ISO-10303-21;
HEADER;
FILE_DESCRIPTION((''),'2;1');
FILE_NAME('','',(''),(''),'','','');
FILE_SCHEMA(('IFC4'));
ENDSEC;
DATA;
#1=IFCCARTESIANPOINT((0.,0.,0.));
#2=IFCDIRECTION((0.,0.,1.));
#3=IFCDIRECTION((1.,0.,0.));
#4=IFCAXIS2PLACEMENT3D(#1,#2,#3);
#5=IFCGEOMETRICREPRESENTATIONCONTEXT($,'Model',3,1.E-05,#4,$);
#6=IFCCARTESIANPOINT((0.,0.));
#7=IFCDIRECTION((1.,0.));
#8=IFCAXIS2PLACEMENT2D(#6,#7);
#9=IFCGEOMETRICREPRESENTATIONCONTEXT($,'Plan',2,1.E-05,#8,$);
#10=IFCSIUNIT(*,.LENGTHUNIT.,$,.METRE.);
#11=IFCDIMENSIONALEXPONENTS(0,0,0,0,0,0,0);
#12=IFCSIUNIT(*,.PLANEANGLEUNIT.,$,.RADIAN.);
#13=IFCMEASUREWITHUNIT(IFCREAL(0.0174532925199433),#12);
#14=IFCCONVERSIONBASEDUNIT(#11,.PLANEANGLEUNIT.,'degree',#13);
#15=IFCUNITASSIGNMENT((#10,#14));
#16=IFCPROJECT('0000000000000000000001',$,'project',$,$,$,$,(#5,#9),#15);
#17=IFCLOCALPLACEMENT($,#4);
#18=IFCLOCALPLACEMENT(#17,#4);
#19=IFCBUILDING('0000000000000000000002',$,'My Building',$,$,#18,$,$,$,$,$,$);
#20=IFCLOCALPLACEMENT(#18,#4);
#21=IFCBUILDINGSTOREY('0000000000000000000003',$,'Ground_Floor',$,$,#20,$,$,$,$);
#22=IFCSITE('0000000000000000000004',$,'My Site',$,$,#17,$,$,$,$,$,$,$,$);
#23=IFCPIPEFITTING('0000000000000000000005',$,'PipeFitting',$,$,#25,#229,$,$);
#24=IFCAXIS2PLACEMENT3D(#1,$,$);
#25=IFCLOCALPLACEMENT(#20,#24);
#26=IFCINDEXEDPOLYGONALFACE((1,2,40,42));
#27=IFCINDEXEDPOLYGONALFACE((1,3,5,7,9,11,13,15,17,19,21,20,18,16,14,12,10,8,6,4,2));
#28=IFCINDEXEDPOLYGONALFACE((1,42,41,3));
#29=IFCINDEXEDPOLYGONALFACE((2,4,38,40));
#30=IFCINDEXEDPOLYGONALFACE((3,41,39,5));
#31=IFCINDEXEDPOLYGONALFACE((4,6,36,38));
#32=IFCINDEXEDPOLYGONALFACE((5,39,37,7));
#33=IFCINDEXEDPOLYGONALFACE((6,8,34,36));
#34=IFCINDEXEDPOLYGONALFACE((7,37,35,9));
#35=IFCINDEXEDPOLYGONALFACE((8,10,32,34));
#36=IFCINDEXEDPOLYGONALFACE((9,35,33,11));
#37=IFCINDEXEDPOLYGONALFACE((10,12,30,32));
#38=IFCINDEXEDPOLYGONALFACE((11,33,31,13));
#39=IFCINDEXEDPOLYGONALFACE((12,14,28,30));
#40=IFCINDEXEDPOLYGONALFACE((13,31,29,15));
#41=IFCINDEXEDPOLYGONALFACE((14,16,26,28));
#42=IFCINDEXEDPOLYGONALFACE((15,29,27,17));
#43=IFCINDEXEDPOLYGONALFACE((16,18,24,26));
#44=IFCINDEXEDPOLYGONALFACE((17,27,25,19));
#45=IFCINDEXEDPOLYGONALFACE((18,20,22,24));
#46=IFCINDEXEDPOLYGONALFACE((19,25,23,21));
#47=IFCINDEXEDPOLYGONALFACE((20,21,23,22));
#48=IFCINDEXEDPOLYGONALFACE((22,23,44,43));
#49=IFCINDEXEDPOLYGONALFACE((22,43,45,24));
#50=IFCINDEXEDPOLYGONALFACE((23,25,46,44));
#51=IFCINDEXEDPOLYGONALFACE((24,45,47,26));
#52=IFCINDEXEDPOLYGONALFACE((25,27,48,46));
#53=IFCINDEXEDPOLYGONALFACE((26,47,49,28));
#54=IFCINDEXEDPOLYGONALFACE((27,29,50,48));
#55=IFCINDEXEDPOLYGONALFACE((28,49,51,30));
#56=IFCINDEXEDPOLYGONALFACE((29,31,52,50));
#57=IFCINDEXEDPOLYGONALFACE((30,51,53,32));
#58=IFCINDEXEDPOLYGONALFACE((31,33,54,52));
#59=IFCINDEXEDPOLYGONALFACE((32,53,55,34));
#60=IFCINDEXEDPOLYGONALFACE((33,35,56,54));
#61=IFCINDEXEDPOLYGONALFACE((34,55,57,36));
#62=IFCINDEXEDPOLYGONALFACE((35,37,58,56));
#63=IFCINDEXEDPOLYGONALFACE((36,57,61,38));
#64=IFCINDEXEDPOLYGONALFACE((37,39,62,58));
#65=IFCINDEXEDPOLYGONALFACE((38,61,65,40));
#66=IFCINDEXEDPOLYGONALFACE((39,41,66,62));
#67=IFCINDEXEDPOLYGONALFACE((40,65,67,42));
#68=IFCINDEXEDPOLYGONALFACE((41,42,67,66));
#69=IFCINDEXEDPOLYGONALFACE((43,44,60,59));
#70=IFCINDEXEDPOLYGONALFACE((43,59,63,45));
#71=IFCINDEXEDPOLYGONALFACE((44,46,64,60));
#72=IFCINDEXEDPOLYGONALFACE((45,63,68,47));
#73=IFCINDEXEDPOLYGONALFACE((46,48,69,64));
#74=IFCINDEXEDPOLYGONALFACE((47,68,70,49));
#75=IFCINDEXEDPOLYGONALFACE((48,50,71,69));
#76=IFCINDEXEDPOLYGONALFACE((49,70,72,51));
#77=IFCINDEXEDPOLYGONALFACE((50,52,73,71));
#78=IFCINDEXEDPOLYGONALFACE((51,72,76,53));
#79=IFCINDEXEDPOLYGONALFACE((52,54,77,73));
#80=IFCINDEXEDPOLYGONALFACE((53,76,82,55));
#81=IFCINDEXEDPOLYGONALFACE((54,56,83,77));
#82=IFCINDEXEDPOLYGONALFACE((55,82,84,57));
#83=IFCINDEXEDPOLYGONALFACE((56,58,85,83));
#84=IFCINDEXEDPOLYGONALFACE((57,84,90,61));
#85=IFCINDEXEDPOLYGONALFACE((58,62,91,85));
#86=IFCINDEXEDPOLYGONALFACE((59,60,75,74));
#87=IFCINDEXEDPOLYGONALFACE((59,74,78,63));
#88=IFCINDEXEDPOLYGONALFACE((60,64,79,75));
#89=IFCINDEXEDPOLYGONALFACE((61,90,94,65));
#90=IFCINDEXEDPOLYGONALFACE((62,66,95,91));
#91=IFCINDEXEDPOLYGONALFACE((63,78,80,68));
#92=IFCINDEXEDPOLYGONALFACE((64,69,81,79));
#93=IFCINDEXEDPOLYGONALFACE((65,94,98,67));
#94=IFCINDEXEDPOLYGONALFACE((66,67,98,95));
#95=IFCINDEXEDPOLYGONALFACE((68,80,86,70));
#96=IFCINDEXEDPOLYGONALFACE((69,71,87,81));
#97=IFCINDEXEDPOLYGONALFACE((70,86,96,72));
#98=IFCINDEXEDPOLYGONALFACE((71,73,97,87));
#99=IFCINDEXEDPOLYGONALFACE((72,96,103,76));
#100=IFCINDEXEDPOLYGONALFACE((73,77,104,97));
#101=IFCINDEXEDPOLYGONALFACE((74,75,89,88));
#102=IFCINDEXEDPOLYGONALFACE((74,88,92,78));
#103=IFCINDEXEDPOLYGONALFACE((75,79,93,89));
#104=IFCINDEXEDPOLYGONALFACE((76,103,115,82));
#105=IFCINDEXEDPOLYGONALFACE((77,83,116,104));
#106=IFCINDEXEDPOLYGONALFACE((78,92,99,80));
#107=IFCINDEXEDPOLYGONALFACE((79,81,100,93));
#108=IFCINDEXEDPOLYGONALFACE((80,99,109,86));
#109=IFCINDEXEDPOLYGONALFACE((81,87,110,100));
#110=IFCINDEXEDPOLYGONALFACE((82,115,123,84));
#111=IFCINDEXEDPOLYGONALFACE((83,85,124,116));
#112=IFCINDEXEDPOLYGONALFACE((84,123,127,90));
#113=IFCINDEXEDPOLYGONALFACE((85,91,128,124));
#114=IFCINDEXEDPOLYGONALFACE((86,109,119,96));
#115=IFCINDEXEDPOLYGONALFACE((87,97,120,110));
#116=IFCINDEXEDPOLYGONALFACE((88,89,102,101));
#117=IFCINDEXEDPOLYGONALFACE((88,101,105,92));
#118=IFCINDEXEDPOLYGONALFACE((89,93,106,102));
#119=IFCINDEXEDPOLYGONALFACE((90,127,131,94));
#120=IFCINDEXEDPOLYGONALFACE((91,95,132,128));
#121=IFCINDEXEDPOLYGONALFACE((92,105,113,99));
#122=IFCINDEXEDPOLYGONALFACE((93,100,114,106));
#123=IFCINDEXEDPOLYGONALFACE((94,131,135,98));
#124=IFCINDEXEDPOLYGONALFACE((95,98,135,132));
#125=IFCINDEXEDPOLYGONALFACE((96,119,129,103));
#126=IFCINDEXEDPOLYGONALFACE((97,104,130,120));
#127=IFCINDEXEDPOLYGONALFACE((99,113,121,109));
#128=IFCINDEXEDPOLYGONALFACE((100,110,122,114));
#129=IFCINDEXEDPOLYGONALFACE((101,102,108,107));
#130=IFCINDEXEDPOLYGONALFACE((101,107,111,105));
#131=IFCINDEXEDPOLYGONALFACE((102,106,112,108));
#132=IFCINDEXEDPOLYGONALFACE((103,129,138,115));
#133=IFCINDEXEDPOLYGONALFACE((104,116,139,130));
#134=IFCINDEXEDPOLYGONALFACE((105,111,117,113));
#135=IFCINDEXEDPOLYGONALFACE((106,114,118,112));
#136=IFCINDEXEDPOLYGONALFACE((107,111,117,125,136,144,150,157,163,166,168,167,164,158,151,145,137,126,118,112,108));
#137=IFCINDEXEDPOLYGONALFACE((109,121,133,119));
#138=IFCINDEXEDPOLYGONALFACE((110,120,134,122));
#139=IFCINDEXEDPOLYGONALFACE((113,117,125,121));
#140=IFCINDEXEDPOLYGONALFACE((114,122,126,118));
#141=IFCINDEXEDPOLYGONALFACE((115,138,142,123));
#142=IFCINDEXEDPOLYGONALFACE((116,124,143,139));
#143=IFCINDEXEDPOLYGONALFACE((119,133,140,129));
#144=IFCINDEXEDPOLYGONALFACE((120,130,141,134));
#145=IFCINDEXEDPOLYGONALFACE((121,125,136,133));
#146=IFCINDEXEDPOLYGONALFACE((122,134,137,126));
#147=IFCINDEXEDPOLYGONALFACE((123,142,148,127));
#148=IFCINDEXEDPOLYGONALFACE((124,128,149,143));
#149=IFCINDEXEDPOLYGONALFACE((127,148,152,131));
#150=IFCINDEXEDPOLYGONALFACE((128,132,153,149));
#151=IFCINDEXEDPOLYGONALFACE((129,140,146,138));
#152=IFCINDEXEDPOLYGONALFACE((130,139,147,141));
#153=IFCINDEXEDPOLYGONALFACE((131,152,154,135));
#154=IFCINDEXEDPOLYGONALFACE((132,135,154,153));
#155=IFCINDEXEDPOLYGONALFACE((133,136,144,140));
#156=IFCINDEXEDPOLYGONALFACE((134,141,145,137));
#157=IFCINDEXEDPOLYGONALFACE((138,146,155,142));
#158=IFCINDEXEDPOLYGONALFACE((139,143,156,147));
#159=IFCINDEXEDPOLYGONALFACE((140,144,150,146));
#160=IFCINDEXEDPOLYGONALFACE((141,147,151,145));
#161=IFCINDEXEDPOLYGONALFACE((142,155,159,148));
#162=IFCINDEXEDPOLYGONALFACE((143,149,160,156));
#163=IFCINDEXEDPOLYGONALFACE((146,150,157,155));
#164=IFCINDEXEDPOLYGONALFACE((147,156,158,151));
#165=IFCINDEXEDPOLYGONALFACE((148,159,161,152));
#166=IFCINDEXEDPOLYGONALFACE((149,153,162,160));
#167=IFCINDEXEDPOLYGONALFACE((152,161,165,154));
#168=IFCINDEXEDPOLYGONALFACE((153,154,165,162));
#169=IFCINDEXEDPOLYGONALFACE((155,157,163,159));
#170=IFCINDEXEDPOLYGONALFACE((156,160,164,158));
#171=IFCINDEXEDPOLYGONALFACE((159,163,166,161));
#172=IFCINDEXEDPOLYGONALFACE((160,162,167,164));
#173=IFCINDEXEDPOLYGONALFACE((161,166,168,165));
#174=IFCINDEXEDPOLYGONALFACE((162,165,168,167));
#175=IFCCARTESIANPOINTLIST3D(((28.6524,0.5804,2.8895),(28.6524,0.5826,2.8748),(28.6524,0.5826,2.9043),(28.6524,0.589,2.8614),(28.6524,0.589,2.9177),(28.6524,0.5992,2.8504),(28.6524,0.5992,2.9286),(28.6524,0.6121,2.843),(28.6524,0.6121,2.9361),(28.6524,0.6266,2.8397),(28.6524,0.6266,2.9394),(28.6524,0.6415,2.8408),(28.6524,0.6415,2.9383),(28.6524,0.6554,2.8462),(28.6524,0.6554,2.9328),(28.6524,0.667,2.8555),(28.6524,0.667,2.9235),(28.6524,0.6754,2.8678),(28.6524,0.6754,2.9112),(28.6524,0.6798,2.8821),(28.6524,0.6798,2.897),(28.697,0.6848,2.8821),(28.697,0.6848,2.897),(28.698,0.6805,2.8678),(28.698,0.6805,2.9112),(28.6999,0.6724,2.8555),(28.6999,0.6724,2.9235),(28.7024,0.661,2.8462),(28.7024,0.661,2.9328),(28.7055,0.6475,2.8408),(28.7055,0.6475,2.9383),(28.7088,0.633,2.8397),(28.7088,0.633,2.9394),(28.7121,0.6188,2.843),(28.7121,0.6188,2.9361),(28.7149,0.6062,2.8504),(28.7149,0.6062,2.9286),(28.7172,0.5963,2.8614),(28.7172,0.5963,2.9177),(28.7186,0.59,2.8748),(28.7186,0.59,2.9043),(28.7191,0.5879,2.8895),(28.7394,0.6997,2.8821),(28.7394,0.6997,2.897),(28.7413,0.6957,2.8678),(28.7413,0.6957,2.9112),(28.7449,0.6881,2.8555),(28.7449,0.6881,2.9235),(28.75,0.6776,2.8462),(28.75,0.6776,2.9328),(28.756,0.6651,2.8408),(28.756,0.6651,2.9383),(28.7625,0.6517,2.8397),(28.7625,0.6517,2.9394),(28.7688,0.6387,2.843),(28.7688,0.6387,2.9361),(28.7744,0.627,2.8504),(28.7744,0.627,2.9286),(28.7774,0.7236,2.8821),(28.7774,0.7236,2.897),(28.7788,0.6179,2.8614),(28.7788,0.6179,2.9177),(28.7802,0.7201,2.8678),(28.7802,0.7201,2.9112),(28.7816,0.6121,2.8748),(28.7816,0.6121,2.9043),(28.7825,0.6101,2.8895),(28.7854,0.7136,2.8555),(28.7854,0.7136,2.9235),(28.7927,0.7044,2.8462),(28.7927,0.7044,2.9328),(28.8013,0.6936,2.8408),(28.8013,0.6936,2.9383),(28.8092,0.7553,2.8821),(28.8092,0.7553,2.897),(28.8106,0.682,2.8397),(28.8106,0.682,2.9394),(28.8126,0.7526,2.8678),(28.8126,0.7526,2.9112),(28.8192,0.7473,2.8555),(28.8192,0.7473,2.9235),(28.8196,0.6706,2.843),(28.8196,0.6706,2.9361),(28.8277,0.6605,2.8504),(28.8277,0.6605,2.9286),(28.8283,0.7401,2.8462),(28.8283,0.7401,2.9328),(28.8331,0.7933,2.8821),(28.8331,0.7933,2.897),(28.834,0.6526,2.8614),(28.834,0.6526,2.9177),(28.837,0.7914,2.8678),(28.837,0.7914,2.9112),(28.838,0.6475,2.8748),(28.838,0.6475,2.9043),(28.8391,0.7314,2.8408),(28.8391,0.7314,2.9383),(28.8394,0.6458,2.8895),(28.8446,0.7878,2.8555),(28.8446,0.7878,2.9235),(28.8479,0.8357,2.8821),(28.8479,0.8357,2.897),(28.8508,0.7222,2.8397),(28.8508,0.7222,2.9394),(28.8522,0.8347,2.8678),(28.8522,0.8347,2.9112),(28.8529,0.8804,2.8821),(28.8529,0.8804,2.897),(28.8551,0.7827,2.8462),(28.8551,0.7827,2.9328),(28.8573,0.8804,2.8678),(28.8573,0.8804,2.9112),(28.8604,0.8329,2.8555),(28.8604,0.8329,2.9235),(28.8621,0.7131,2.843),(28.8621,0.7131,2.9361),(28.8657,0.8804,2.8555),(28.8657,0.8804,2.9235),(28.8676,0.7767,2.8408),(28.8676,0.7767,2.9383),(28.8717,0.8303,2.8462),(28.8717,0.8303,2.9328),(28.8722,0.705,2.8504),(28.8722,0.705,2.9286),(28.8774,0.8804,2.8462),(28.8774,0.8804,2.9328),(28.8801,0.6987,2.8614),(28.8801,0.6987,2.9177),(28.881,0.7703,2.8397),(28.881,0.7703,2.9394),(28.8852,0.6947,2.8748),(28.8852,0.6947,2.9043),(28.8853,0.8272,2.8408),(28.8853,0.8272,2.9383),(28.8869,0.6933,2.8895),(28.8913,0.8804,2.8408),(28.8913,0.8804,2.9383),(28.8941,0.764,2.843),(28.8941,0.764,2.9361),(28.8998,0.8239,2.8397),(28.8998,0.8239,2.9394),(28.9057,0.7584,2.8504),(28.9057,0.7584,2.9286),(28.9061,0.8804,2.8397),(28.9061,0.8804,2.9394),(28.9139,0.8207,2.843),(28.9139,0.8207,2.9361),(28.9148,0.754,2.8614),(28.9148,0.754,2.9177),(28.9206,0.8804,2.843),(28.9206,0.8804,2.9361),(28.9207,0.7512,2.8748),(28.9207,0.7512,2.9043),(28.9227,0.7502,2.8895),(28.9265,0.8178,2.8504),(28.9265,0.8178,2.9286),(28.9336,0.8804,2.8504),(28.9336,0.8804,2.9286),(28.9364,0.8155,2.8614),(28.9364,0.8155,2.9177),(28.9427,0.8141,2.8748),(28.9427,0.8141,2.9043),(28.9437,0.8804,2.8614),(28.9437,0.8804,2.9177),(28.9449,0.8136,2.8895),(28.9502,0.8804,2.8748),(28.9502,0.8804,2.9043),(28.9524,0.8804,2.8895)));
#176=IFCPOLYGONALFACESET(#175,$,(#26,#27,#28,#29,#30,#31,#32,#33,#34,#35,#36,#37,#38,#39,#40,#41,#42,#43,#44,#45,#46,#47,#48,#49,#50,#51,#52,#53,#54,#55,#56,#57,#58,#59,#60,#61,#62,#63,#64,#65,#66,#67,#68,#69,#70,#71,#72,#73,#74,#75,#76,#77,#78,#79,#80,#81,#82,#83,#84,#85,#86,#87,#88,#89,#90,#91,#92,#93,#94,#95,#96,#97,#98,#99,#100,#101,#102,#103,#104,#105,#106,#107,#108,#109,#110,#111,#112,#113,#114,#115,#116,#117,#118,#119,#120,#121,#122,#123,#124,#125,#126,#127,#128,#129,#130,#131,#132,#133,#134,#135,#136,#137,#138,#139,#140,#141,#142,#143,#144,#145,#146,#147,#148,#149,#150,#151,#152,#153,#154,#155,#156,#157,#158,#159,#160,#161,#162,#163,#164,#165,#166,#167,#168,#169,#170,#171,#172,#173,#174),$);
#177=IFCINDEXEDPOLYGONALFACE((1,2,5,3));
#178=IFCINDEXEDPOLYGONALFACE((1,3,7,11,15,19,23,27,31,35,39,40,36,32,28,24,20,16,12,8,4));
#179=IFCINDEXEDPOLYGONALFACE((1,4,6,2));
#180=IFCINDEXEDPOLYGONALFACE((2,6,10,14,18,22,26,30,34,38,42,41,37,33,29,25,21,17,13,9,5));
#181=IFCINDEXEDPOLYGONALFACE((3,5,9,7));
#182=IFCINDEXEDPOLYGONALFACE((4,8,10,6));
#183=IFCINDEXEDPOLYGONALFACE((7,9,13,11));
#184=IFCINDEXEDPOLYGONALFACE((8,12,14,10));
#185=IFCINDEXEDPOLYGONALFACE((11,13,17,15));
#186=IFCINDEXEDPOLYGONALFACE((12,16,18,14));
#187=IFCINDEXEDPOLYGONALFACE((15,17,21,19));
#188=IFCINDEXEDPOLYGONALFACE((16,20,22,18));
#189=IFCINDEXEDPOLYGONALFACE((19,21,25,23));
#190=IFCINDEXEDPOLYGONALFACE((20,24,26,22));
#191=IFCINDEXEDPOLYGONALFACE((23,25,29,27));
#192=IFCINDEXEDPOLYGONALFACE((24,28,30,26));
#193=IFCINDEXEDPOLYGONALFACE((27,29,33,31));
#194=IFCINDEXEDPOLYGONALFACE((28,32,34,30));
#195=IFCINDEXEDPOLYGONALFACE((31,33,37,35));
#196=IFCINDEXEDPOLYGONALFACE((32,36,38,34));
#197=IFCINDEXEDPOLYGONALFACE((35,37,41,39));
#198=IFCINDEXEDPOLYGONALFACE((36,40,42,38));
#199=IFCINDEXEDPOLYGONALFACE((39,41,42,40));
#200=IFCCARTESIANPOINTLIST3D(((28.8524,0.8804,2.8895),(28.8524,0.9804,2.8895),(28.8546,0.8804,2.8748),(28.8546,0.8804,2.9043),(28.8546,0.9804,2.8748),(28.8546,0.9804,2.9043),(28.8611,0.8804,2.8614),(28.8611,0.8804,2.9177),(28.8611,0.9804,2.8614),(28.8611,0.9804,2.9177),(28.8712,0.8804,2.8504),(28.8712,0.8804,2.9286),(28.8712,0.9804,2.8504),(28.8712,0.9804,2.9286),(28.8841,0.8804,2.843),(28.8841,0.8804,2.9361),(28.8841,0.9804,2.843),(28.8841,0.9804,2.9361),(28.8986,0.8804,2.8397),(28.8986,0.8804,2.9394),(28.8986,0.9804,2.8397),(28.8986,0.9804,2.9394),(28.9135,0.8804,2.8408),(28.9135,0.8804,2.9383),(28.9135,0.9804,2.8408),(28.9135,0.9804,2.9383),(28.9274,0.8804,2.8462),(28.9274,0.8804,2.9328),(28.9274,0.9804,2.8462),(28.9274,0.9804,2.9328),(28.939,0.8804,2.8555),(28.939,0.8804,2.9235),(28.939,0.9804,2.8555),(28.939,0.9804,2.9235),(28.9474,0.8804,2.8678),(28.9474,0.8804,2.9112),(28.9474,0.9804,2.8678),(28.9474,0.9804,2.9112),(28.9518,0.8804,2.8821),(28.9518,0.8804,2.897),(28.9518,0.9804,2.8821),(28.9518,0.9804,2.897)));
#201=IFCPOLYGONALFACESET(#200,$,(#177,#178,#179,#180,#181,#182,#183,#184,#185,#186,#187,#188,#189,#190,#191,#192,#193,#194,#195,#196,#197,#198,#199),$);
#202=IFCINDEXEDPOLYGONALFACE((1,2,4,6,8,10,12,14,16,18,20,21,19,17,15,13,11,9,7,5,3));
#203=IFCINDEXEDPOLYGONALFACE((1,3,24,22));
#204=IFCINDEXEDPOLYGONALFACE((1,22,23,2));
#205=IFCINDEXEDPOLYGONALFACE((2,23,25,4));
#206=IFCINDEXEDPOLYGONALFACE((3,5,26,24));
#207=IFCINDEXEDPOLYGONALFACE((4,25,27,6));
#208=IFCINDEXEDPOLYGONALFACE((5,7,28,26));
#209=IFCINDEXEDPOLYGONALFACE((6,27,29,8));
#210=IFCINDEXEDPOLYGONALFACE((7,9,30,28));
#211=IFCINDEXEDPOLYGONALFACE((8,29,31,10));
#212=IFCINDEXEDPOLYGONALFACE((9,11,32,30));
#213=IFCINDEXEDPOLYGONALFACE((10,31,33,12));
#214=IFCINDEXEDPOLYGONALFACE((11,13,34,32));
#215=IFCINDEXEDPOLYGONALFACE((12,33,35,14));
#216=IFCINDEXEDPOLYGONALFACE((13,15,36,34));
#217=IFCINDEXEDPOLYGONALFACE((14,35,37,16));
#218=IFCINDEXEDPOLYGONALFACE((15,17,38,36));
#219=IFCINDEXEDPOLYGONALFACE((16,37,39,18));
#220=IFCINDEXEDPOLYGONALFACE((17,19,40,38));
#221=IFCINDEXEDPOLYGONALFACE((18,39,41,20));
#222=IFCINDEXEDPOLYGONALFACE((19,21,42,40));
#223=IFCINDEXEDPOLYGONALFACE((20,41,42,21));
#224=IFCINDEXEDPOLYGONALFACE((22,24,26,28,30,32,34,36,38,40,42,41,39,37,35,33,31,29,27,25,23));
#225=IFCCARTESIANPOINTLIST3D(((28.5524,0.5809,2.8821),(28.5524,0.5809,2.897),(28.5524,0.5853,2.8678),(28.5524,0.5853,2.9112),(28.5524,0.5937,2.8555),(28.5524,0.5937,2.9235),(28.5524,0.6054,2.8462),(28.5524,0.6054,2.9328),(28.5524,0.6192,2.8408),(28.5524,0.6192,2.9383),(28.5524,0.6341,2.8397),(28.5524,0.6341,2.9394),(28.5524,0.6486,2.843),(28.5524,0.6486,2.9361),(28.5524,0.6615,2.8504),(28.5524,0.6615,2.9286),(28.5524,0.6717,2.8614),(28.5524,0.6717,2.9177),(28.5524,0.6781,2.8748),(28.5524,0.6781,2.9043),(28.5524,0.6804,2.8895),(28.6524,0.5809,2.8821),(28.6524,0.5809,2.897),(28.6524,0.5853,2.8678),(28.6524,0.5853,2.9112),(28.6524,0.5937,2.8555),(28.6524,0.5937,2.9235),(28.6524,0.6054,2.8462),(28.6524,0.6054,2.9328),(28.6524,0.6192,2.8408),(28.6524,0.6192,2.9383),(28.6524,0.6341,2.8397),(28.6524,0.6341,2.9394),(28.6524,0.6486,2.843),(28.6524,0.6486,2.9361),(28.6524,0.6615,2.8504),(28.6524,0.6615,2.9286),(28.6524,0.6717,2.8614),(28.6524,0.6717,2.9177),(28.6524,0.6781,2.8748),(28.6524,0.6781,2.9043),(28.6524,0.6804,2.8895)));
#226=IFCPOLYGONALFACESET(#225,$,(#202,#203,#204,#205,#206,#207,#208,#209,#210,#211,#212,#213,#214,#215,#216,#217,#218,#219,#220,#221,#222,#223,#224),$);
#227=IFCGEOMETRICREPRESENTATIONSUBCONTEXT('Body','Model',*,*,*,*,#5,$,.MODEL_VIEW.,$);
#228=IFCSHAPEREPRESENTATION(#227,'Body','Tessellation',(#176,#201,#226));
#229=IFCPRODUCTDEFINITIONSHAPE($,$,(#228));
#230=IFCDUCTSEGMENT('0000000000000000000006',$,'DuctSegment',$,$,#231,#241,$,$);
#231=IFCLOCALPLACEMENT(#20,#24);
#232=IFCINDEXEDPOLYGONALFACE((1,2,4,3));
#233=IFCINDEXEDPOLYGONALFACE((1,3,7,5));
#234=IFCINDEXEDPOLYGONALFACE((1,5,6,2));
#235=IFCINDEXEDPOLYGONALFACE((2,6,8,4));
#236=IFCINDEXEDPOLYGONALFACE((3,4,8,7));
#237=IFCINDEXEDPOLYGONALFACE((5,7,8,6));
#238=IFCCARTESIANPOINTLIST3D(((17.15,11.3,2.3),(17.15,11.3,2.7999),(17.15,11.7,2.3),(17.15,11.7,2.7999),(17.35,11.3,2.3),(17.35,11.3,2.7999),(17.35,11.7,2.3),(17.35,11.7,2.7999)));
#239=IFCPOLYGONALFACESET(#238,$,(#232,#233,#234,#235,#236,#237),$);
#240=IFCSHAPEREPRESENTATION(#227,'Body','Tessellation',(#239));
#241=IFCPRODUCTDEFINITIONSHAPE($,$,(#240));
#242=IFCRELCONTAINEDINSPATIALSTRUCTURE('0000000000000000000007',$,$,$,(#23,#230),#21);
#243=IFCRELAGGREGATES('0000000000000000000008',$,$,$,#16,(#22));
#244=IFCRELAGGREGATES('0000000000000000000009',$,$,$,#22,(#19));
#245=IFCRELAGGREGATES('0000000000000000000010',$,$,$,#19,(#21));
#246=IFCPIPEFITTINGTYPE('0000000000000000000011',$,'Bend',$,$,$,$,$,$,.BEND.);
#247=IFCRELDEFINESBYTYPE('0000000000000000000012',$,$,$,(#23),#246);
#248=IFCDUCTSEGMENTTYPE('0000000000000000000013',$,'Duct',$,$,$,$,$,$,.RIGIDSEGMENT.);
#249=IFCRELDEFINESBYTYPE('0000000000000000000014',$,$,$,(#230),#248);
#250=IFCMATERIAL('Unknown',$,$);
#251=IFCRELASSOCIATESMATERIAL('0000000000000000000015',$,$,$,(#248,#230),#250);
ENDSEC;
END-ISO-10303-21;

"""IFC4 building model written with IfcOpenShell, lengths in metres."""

from ifc_helpers import new_model, entity, si_unit, converted_unit, frame, origin_with_axes, origin_2d_with_axis, place, context, subcontext, project, spatial, rectangle, circle, extrude, source, transform, mapped, material, material_profile, profile_set, profile_usage, type_object, type_shapes, element, save


model = new_model("IFC4")

# Units and contexts
model_context = context("Model", 3, precision=1e-05, world=origin_with_axes())
plan_context = context("Plan", 2, precision=1e-05, world=origin_2d_with_axis())
body_context_1 = subcontext(model_context, "Body", "Model", "MODEL_VIEW")
ifc_project = project(units=[si_unit("LENGTHUNIT", "METRE"), converted_unit("PLANEANGLEUNIT", "degree", entity("IfcReal", 0.0174532925199433), si_unit("PLANEANGLEUNIT", "RADIAN"), dimensions=[0, 0, 0, 0, 0, 0, 0])], contexts=[model_context, plan_context])

# Site, building, storey
site_placement = place(None, origin_with_axes())
site = spatial("IfcSite", under=ifc_project, at=site_placement, Name="My Site")
building_placement = place(site_placement, origin_with_axes())
building = spatial("IfcBuilding", under=site, at=building_placement, Name="My Building")
storey_placement = place(building_placement, origin_with_axes())
storey = spatial("IfcBuildingStorey", under=building, at=storey_placement, Name="Ground_Floor")

# Shared definitions
ifc_material = material(Name="Unknown")

# Pipe fitting
pipe_fitting_type = type_object("IfcPipeFittingType", Name="Bend", PredefinedType="BEND")
shared_shape_1 = source(origin_with_axes(), body_context_1, "Body", "SolidModel", [
    entity("IfcSweptDiskSolid", entity("IfcIndexedPolyCurve", entity("IfcCartesianPointList3D", [[0.0, 0.0, -0.1], [0.0732, 0.0, -0.2768], [0.25, 0.0, -0.35]]), [entity("IfcArcIndex", [1, 2, 3])]), 0.05),
    extrude(circle(Radius=0.05), origin_with_axes(), (0.0, 0.0, -1.0), 0.1),
    extrude(circle(Radius=0.05), frame((0.25, 0.0, -0.35), z_axis=(1.0, 0.0, 0.0), x_axis=(0.0, 0.0, 1.0)), (0.0, 0.0, 1.0), 0.1),
])
type_shapes(pipe_fitting_type, [shared_shape_1])
pipe_fitting_placement = place(storey_placement, frame((28.9024, 0.9804, 2.8895), z_axis=(-0.000002, 1.0, 0.0), x_axis=(-1.0, -0.000002, 0.0)))
element("IfcPipeFitting", 1, at=pipe_fitting_placement, inside=storey, type_object=pipe_fitting_type, Name="PipeFitting", context=body_context_1, shape_type="MappedRepresentation", body=[
    mapped(shared_shape_1, transform((0.0, 0.0, 0.0), x_axis=(1.0, 0.0, 0.0), y_axis=(0.0, 1.0, 0.0), z_axis=(0.0, 0.0, 1.0), scale=1.0)),
])

# Duct segment
ifc_material_profile_1 = material_profile(ifc_material, rectangle(XDim=0.4, YDim=0.2))
ifc_profile_set_1 = profile_set([ifc_material_profile_1])
ifc_profile_usage_1 = profile_usage(ifc_profile_set_1, cardinal=5)
duct_segment_type = type_object("IfcDuctSegmentType", Name="Duct", PredefinedType="RIGIDSEGMENT", material=ifc_profile_set_1)
duct_segment_placement = place(storey_placement, frame((17.25, 11.5, 2.7999), z_axis=(0.0, 0.0, -1.0), x_axis=(0.0, 1.0, 0.0)))
element("IfcDuctSegment", 2, at=duct_segment_placement, inside=storey, type_object=duct_segment_type, material=ifc_profile_usage_1, Name="DuctSegment", context=body_context_1, shape_type="SweptSolid", body=[
    extrude(rectangle(XDim=0.4, YDim=0.2), origin_with_axes(), (0.0, 0.0, 1.0), 0.5),
])

save(model, "model.ifc")
